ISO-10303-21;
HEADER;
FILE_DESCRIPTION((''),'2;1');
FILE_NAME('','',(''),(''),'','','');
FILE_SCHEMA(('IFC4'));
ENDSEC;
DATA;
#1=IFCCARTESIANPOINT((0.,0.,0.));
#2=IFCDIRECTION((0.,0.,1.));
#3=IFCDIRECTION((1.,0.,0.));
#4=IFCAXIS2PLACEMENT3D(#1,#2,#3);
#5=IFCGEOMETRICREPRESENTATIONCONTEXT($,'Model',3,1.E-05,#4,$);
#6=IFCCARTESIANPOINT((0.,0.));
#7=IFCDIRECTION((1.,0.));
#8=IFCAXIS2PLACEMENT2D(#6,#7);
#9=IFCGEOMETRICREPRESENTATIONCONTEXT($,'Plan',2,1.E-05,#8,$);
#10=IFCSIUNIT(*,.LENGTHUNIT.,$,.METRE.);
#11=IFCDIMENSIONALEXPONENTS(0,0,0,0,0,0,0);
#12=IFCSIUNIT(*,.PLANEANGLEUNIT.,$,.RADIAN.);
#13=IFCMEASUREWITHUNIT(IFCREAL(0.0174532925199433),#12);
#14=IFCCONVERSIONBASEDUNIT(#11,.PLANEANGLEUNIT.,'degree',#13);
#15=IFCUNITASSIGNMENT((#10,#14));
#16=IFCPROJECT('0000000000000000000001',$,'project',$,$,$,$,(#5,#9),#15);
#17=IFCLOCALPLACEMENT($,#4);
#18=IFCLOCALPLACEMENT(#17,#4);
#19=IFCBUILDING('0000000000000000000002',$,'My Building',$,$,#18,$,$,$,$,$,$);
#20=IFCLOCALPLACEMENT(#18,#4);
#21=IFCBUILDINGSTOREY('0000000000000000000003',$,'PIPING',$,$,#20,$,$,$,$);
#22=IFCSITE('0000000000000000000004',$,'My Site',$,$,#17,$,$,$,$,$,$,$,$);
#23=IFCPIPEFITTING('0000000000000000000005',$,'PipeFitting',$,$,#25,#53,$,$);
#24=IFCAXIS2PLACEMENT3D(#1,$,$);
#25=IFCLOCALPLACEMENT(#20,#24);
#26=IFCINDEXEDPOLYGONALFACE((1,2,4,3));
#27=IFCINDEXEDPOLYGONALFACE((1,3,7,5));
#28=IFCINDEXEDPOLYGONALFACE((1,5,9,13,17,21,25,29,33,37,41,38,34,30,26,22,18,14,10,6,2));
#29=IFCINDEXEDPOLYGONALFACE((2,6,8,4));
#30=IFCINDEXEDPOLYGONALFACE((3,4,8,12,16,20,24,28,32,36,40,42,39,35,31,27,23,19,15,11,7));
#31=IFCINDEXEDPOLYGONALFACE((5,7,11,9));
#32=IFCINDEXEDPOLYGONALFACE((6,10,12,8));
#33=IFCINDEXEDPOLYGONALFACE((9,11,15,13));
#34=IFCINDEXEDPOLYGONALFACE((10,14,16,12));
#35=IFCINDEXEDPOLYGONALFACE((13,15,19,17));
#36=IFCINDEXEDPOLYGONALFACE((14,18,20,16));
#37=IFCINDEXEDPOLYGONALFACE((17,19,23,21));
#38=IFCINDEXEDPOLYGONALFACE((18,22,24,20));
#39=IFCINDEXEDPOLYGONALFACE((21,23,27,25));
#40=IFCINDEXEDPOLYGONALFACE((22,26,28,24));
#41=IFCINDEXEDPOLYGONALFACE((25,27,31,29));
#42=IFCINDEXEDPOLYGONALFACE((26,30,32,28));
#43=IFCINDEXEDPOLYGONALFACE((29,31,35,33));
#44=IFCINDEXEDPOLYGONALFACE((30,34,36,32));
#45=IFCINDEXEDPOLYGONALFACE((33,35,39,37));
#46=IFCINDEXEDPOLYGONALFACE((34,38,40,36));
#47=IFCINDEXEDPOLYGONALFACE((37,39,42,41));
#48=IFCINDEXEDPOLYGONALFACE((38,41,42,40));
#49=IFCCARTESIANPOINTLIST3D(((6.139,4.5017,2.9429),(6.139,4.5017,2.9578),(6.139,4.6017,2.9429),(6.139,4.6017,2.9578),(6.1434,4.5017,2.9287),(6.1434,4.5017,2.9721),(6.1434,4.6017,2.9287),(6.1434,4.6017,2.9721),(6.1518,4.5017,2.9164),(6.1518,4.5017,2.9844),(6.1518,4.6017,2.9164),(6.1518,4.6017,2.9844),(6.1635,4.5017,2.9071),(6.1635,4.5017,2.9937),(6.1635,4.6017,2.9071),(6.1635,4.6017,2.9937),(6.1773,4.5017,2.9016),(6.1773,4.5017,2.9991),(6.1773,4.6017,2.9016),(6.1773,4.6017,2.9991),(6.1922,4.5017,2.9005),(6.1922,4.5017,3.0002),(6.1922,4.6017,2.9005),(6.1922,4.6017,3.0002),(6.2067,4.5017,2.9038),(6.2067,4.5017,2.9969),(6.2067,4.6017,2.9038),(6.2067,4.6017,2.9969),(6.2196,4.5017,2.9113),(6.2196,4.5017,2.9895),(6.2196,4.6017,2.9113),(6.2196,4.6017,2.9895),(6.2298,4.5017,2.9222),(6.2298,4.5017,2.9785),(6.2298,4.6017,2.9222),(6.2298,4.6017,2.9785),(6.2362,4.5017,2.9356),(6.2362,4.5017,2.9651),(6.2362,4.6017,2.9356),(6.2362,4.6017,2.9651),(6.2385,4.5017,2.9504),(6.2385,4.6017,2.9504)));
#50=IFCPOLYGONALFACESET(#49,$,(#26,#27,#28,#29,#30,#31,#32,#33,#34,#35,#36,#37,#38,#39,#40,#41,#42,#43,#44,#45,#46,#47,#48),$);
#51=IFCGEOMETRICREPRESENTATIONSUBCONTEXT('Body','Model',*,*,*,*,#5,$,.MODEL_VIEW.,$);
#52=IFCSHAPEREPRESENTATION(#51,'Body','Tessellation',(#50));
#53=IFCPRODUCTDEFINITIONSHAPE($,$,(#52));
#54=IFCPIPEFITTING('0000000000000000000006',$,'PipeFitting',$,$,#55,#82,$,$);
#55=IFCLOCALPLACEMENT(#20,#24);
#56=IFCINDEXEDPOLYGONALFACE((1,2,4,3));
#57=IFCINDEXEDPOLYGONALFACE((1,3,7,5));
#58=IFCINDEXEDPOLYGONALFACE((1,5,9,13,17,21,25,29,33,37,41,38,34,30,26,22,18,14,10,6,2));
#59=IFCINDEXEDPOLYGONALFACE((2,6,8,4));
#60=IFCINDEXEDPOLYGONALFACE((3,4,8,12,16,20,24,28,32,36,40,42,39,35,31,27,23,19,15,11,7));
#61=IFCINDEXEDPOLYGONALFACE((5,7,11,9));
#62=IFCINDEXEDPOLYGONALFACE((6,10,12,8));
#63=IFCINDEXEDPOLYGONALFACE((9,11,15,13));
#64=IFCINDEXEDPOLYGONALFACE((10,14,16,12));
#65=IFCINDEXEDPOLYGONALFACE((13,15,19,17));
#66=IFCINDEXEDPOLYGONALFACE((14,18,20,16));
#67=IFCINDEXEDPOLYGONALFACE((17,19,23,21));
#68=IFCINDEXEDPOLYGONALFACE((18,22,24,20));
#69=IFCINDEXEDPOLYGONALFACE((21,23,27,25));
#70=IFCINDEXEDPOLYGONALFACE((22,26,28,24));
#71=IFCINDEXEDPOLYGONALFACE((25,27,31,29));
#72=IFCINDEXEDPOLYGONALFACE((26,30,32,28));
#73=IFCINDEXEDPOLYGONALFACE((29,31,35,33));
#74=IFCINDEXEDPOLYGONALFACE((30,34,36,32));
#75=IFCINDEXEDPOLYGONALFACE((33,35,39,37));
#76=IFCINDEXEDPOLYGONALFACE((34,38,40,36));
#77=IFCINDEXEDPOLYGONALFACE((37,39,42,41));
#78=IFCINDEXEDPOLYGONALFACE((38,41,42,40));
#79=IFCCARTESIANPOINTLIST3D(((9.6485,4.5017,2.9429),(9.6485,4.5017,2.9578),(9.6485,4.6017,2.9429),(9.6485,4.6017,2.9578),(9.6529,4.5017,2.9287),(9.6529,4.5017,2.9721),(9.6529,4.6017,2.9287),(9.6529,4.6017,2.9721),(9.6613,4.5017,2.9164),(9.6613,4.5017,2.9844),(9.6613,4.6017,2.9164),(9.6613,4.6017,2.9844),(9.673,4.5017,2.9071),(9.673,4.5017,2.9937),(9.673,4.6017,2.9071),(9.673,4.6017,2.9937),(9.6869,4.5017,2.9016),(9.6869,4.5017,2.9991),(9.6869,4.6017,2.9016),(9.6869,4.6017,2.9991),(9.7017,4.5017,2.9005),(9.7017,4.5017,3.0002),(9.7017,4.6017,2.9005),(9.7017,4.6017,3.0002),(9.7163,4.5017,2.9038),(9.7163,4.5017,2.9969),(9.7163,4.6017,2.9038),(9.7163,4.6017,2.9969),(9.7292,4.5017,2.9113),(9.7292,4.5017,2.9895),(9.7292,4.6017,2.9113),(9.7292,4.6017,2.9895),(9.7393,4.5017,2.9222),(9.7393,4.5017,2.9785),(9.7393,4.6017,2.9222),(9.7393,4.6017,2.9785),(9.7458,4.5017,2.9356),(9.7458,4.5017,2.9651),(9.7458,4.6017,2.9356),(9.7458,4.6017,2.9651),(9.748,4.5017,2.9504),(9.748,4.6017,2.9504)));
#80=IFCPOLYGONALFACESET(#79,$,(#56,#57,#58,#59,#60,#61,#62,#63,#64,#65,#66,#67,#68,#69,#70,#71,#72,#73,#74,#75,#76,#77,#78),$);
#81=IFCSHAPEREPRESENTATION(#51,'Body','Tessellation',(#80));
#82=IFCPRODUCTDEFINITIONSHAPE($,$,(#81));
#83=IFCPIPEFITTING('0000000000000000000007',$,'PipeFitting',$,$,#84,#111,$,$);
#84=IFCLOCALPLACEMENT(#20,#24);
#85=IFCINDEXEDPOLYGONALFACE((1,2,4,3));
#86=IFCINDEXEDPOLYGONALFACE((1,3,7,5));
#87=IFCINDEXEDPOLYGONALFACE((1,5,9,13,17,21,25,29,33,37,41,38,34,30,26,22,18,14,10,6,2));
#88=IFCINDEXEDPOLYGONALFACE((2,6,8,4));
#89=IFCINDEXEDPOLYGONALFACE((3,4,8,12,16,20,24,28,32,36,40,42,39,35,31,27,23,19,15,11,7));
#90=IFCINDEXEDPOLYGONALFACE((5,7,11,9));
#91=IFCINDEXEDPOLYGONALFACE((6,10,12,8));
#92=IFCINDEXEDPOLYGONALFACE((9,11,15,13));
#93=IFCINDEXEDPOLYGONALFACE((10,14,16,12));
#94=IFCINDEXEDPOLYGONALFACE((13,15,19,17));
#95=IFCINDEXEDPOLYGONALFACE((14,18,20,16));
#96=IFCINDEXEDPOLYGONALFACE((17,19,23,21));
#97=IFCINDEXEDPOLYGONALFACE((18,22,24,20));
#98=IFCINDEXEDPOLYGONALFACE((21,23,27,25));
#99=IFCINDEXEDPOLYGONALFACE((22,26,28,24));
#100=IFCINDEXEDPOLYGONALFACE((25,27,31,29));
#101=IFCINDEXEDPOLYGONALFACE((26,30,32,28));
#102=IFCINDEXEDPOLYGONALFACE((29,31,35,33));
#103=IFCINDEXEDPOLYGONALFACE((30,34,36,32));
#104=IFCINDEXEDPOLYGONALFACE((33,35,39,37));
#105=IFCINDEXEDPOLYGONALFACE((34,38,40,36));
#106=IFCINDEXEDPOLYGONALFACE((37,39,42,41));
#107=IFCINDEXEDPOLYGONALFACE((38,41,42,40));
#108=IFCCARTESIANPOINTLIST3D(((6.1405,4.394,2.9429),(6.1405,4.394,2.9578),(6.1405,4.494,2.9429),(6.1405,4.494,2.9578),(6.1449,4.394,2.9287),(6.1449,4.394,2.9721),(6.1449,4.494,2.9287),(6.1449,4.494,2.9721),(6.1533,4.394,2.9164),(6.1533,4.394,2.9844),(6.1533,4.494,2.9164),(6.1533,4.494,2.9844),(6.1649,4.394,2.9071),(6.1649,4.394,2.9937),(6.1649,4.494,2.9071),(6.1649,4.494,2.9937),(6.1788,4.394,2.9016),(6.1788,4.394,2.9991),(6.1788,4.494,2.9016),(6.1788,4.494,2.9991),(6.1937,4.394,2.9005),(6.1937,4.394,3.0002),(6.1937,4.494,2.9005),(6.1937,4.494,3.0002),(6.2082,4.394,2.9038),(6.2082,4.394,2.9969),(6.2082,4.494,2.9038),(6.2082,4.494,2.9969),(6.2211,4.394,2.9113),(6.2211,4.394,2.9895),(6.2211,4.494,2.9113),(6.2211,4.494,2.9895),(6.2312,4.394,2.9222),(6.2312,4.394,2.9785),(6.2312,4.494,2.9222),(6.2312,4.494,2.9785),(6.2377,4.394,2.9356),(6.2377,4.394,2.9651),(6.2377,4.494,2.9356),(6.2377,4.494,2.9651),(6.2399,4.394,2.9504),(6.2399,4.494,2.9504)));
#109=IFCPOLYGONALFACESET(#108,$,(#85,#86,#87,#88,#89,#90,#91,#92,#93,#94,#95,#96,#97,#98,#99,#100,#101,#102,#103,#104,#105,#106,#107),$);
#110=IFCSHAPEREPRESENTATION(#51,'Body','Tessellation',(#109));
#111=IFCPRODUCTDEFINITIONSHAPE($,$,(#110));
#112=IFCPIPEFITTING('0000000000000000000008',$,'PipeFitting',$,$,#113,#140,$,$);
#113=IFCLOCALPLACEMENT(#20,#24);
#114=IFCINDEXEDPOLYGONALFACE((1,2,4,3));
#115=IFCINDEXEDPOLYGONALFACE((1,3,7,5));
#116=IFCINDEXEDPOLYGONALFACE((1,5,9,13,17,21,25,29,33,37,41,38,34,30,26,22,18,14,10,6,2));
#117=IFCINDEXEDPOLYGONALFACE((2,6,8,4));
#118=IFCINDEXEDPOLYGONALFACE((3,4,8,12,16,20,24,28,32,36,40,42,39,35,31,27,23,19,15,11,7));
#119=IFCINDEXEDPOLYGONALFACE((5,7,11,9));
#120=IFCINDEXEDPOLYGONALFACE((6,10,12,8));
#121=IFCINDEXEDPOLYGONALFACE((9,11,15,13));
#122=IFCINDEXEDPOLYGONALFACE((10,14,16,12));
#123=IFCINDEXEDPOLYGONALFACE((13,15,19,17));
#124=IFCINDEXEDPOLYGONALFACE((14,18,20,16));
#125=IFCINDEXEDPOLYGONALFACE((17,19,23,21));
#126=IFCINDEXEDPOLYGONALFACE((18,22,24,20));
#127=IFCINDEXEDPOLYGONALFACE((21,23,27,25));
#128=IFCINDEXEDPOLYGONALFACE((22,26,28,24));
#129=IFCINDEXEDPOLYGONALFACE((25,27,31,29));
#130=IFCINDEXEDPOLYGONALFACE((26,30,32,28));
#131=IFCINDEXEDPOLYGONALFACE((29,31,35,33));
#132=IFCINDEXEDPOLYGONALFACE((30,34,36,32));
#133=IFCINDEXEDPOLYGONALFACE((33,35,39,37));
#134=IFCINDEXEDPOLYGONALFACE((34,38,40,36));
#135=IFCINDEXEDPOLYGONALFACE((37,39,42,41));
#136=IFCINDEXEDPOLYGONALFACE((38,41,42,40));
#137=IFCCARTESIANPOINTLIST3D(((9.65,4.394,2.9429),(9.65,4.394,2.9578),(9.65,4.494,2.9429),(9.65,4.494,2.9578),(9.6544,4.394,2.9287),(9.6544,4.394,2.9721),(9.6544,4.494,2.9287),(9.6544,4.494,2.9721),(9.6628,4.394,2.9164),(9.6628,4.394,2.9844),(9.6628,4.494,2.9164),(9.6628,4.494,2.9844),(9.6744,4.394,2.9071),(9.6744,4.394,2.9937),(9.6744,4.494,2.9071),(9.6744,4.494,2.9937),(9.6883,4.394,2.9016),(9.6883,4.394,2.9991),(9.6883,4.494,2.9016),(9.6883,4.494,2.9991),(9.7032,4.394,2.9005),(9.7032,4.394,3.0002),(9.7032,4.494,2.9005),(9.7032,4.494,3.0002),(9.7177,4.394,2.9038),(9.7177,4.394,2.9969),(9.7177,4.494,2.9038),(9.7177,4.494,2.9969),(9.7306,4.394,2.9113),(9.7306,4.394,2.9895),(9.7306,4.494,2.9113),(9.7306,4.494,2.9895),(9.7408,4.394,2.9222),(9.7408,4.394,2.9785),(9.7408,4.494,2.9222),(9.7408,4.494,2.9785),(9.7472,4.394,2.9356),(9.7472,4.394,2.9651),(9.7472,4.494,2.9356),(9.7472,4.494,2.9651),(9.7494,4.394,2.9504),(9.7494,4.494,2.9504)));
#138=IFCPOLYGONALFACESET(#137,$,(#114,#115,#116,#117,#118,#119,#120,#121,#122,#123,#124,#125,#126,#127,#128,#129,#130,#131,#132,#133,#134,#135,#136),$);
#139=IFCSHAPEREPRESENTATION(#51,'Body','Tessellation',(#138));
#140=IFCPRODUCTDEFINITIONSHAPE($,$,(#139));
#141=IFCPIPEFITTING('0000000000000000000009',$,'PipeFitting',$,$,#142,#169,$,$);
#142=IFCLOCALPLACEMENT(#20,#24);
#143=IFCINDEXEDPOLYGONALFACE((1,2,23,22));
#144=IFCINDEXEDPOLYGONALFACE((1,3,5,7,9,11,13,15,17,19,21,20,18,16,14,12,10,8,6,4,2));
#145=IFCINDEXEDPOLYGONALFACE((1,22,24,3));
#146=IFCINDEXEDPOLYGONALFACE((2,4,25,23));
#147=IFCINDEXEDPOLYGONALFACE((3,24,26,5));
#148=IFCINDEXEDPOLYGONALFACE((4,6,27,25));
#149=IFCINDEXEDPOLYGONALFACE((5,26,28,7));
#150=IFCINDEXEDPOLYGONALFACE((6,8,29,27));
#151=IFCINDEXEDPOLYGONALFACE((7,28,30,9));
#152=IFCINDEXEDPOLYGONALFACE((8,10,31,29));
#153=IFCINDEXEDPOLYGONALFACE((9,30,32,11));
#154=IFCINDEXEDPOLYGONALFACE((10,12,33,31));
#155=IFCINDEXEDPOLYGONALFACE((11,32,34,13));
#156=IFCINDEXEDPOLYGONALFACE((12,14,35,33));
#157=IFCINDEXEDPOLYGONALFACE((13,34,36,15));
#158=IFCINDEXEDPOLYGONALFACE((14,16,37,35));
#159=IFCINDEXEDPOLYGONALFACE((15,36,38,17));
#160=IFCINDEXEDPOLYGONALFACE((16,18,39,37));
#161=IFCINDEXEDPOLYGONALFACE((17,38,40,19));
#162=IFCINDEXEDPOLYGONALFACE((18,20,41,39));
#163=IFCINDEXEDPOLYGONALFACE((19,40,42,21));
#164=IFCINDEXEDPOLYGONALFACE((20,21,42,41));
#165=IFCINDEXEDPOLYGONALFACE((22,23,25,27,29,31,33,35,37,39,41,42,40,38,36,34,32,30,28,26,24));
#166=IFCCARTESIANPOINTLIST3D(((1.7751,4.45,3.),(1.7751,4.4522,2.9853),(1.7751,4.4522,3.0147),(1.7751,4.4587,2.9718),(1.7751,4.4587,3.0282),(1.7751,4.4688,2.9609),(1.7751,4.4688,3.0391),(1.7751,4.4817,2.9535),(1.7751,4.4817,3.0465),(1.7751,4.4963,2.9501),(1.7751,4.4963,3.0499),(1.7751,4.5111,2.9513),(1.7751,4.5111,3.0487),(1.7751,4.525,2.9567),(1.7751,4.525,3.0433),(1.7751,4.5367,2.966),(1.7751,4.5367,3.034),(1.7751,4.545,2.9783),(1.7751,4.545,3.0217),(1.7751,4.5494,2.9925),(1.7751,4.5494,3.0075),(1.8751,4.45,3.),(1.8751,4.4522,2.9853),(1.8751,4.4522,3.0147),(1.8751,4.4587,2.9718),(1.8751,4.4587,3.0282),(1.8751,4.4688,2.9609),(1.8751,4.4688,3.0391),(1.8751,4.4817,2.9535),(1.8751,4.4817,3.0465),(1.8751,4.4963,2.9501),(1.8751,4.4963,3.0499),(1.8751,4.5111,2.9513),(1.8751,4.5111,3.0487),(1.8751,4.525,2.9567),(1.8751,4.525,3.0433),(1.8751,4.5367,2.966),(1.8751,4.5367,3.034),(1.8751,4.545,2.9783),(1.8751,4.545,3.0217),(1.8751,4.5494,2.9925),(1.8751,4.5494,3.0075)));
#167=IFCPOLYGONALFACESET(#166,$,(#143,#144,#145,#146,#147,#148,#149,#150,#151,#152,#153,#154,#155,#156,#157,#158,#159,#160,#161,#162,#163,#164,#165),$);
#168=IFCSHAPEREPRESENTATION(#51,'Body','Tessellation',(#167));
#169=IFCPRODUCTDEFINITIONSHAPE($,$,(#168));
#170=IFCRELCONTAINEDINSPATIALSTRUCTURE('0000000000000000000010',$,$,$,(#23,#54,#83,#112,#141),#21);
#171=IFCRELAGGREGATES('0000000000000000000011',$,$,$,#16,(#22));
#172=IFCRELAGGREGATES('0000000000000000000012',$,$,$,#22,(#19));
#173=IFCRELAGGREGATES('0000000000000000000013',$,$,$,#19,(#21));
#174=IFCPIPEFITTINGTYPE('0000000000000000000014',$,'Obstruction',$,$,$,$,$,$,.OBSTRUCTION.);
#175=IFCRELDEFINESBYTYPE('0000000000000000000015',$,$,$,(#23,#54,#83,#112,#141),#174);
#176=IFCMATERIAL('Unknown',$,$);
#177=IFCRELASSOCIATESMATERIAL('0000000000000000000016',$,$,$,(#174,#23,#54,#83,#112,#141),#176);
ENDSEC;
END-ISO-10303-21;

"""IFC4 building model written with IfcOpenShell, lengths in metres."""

from ifc_helpers import new_model, entity, si_unit, converted_unit, frame, origin_with_axes, origin_2d_with_axis, place, context, subcontext, project, spatial, circle, extrude, material, material_profile, profile_set, profile_usage, type_object, element, save


model = new_model("IFC4")

# Units and contexts
model_context = context("Model", 3, precision=1e-05, world=origin_with_axes())
plan_context = context("Plan", 2, precision=1e-05, world=origin_2d_with_axis())
body_context = subcontext(model_context, "Body", "Model", "MODEL_VIEW")
ifc_project = project(units=[si_unit("LENGTHUNIT", "METRE"), converted_unit("PLANEANGLEUNIT", "degree", entity("IfcReal", 0.0174532925199433), si_unit("PLANEANGLEUNIT", "RADIAN"), dimensions=[0, 0, 0, 0, 0, 0, 0])], contexts=[model_context, plan_context])

# Site, building, storey
site_placement = place(None, origin_with_axes())
site = spatial("IfcSite", under=ifc_project, at=site_placement, Name="My Site")
building_placement = place(site_placement, origin_with_axes())
building = spatial("IfcBuilding", under=site, at=building_placement, Name="My Building")
storey_placement = place(building_placement, origin_with_axes())
storey = spatial("IfcBuildingStorey", under=building, at=storey_placement, Name="PIPING")

# Shared definitions
ifc_material = material(Name="Unknown")

# Pipe fittings
ifc_material_profile_1 = material_profile(ifc_material, circle(Radius=0.05))
ifc_profile_set_1 = profile_set([ifc_material_profile_1])
ifc_profile_usage_1 = profile_usage(ifc_profile_set_1, cardinal=5)
pipe_fitting_type_1 = type_object("IfcPipeFittingType", Name="Obstruction", PredefinedType="OBSTRUCTION", material=ifc_profile_set_1)
pipe_fitting_1_placement = place(storey_placement, frame((6.1885, 4.5017, 2.9504), z_axis=(0.0, 1.0, 0.0), x_axis=(1.0, 0.0, 0.0)))
element("IfcPipeFitting", 1, at=pipe_fitting_1_placement, inside=storey, type_object=pipe_fitting_type_1, material=ifc_profile_usage_1, Name="PipeFitting", context=body_context, shape_type="SweptSolid", body=[
    extrude(circle(Radius=0.05), origin_with_axes(), (0.0, 0.0, 1.0), 0.1),
])
ifc_profile_usage_2 = profile_usage(ifc_profile_set_1, cardinal=5)
pipe_fitting_2_placement = place(storey_placement, frame((9.698, 4.5017, 2.9504), z_axis=(0.0, 1.0, 0.0), x_axis=(1.0, 0.0, 0.0)))
element("IfcPipeFitting", 2, at=pipe_fitting_2_placement, inside=storey, type_object=pipe_fitting_type_1, material=ifc_profile_usage_2, Name="PipeFitting", context=body_context, shape_type="SweptSolid", body=[
    extrude(circle(Radius=0.05), origin_with_axes(), (0.0, 0.0, 1.0), 0.1),
])
ifc_profile_usage_3 = profile_usage(ifc_profile_set_1, cardinal=5)
pipe_fitting_3_placement = place(storey_placement, frame((6.1899, 4.394, 2.9504), z_axis=(0.0, 1.0, 0.0), x_axis=(1.0, 0.0, 0.0)))
element("IfcPipeFitting", 3, at=pipe_fitting_3_placement, inside=storey, type_object=pipe_fitting_type_1, material=ifc_profile_usage_3, Name="PipeFitting", context=body_context, shape_type="SweptSolid", body=[
    extrude(circle(Radius=0.05), origin_with_axes(), (0.0, 0.0, 1.0), 0.1),
])
ifc_profile_usage_4 = profile_usage(ifc_profile_set_1, cardinal=5)
pipe_fitting_4_placement = place(storey_placement, frame((9.6994, 4.394, 2.9504), z_axis=(0.0, 1.0, 0.0), x_axis=(1.0, 0.0, 0.0)))
element("IfcPipeFitting", 4, at=pipe_fitting_4_placement, inside=storey, type_object=pipe_fitting_type_1, material=ifc_profile_usage_4, Name="PipeFitting", context=body_context, shape_type="SweptSolid", body=[
    extrude(circle(Radius=0.05), origin_with_axes(), (0.0, 0.0, 1.0), 0.1),
])
ifc_profile_usage_5 = profile_usage(ifc_profile_set_1, cardinal=5)
pipe_fitting_5_placement = place(storey_placement, frame((1.8751, 4.5, 3.0), z_axis=(-1.0, 0.0, 0.0), x_axis=(0.0, -1.0, 0.0)))
element("IfcPipeFitting", 5, at=pipe_fitting_5_placement, inside=storey, type_object=pipe_fitting_type_1, material=ifc_profile_usage_5, Name="PipeFitting", context=body_context, shape_type="SweptSolid", body=[
    extrude(circle(Radius=0.05), origin_with_axes(), (0.0, 0.0, 1.0), 0.1),
])

save(model, "model.ifc")
